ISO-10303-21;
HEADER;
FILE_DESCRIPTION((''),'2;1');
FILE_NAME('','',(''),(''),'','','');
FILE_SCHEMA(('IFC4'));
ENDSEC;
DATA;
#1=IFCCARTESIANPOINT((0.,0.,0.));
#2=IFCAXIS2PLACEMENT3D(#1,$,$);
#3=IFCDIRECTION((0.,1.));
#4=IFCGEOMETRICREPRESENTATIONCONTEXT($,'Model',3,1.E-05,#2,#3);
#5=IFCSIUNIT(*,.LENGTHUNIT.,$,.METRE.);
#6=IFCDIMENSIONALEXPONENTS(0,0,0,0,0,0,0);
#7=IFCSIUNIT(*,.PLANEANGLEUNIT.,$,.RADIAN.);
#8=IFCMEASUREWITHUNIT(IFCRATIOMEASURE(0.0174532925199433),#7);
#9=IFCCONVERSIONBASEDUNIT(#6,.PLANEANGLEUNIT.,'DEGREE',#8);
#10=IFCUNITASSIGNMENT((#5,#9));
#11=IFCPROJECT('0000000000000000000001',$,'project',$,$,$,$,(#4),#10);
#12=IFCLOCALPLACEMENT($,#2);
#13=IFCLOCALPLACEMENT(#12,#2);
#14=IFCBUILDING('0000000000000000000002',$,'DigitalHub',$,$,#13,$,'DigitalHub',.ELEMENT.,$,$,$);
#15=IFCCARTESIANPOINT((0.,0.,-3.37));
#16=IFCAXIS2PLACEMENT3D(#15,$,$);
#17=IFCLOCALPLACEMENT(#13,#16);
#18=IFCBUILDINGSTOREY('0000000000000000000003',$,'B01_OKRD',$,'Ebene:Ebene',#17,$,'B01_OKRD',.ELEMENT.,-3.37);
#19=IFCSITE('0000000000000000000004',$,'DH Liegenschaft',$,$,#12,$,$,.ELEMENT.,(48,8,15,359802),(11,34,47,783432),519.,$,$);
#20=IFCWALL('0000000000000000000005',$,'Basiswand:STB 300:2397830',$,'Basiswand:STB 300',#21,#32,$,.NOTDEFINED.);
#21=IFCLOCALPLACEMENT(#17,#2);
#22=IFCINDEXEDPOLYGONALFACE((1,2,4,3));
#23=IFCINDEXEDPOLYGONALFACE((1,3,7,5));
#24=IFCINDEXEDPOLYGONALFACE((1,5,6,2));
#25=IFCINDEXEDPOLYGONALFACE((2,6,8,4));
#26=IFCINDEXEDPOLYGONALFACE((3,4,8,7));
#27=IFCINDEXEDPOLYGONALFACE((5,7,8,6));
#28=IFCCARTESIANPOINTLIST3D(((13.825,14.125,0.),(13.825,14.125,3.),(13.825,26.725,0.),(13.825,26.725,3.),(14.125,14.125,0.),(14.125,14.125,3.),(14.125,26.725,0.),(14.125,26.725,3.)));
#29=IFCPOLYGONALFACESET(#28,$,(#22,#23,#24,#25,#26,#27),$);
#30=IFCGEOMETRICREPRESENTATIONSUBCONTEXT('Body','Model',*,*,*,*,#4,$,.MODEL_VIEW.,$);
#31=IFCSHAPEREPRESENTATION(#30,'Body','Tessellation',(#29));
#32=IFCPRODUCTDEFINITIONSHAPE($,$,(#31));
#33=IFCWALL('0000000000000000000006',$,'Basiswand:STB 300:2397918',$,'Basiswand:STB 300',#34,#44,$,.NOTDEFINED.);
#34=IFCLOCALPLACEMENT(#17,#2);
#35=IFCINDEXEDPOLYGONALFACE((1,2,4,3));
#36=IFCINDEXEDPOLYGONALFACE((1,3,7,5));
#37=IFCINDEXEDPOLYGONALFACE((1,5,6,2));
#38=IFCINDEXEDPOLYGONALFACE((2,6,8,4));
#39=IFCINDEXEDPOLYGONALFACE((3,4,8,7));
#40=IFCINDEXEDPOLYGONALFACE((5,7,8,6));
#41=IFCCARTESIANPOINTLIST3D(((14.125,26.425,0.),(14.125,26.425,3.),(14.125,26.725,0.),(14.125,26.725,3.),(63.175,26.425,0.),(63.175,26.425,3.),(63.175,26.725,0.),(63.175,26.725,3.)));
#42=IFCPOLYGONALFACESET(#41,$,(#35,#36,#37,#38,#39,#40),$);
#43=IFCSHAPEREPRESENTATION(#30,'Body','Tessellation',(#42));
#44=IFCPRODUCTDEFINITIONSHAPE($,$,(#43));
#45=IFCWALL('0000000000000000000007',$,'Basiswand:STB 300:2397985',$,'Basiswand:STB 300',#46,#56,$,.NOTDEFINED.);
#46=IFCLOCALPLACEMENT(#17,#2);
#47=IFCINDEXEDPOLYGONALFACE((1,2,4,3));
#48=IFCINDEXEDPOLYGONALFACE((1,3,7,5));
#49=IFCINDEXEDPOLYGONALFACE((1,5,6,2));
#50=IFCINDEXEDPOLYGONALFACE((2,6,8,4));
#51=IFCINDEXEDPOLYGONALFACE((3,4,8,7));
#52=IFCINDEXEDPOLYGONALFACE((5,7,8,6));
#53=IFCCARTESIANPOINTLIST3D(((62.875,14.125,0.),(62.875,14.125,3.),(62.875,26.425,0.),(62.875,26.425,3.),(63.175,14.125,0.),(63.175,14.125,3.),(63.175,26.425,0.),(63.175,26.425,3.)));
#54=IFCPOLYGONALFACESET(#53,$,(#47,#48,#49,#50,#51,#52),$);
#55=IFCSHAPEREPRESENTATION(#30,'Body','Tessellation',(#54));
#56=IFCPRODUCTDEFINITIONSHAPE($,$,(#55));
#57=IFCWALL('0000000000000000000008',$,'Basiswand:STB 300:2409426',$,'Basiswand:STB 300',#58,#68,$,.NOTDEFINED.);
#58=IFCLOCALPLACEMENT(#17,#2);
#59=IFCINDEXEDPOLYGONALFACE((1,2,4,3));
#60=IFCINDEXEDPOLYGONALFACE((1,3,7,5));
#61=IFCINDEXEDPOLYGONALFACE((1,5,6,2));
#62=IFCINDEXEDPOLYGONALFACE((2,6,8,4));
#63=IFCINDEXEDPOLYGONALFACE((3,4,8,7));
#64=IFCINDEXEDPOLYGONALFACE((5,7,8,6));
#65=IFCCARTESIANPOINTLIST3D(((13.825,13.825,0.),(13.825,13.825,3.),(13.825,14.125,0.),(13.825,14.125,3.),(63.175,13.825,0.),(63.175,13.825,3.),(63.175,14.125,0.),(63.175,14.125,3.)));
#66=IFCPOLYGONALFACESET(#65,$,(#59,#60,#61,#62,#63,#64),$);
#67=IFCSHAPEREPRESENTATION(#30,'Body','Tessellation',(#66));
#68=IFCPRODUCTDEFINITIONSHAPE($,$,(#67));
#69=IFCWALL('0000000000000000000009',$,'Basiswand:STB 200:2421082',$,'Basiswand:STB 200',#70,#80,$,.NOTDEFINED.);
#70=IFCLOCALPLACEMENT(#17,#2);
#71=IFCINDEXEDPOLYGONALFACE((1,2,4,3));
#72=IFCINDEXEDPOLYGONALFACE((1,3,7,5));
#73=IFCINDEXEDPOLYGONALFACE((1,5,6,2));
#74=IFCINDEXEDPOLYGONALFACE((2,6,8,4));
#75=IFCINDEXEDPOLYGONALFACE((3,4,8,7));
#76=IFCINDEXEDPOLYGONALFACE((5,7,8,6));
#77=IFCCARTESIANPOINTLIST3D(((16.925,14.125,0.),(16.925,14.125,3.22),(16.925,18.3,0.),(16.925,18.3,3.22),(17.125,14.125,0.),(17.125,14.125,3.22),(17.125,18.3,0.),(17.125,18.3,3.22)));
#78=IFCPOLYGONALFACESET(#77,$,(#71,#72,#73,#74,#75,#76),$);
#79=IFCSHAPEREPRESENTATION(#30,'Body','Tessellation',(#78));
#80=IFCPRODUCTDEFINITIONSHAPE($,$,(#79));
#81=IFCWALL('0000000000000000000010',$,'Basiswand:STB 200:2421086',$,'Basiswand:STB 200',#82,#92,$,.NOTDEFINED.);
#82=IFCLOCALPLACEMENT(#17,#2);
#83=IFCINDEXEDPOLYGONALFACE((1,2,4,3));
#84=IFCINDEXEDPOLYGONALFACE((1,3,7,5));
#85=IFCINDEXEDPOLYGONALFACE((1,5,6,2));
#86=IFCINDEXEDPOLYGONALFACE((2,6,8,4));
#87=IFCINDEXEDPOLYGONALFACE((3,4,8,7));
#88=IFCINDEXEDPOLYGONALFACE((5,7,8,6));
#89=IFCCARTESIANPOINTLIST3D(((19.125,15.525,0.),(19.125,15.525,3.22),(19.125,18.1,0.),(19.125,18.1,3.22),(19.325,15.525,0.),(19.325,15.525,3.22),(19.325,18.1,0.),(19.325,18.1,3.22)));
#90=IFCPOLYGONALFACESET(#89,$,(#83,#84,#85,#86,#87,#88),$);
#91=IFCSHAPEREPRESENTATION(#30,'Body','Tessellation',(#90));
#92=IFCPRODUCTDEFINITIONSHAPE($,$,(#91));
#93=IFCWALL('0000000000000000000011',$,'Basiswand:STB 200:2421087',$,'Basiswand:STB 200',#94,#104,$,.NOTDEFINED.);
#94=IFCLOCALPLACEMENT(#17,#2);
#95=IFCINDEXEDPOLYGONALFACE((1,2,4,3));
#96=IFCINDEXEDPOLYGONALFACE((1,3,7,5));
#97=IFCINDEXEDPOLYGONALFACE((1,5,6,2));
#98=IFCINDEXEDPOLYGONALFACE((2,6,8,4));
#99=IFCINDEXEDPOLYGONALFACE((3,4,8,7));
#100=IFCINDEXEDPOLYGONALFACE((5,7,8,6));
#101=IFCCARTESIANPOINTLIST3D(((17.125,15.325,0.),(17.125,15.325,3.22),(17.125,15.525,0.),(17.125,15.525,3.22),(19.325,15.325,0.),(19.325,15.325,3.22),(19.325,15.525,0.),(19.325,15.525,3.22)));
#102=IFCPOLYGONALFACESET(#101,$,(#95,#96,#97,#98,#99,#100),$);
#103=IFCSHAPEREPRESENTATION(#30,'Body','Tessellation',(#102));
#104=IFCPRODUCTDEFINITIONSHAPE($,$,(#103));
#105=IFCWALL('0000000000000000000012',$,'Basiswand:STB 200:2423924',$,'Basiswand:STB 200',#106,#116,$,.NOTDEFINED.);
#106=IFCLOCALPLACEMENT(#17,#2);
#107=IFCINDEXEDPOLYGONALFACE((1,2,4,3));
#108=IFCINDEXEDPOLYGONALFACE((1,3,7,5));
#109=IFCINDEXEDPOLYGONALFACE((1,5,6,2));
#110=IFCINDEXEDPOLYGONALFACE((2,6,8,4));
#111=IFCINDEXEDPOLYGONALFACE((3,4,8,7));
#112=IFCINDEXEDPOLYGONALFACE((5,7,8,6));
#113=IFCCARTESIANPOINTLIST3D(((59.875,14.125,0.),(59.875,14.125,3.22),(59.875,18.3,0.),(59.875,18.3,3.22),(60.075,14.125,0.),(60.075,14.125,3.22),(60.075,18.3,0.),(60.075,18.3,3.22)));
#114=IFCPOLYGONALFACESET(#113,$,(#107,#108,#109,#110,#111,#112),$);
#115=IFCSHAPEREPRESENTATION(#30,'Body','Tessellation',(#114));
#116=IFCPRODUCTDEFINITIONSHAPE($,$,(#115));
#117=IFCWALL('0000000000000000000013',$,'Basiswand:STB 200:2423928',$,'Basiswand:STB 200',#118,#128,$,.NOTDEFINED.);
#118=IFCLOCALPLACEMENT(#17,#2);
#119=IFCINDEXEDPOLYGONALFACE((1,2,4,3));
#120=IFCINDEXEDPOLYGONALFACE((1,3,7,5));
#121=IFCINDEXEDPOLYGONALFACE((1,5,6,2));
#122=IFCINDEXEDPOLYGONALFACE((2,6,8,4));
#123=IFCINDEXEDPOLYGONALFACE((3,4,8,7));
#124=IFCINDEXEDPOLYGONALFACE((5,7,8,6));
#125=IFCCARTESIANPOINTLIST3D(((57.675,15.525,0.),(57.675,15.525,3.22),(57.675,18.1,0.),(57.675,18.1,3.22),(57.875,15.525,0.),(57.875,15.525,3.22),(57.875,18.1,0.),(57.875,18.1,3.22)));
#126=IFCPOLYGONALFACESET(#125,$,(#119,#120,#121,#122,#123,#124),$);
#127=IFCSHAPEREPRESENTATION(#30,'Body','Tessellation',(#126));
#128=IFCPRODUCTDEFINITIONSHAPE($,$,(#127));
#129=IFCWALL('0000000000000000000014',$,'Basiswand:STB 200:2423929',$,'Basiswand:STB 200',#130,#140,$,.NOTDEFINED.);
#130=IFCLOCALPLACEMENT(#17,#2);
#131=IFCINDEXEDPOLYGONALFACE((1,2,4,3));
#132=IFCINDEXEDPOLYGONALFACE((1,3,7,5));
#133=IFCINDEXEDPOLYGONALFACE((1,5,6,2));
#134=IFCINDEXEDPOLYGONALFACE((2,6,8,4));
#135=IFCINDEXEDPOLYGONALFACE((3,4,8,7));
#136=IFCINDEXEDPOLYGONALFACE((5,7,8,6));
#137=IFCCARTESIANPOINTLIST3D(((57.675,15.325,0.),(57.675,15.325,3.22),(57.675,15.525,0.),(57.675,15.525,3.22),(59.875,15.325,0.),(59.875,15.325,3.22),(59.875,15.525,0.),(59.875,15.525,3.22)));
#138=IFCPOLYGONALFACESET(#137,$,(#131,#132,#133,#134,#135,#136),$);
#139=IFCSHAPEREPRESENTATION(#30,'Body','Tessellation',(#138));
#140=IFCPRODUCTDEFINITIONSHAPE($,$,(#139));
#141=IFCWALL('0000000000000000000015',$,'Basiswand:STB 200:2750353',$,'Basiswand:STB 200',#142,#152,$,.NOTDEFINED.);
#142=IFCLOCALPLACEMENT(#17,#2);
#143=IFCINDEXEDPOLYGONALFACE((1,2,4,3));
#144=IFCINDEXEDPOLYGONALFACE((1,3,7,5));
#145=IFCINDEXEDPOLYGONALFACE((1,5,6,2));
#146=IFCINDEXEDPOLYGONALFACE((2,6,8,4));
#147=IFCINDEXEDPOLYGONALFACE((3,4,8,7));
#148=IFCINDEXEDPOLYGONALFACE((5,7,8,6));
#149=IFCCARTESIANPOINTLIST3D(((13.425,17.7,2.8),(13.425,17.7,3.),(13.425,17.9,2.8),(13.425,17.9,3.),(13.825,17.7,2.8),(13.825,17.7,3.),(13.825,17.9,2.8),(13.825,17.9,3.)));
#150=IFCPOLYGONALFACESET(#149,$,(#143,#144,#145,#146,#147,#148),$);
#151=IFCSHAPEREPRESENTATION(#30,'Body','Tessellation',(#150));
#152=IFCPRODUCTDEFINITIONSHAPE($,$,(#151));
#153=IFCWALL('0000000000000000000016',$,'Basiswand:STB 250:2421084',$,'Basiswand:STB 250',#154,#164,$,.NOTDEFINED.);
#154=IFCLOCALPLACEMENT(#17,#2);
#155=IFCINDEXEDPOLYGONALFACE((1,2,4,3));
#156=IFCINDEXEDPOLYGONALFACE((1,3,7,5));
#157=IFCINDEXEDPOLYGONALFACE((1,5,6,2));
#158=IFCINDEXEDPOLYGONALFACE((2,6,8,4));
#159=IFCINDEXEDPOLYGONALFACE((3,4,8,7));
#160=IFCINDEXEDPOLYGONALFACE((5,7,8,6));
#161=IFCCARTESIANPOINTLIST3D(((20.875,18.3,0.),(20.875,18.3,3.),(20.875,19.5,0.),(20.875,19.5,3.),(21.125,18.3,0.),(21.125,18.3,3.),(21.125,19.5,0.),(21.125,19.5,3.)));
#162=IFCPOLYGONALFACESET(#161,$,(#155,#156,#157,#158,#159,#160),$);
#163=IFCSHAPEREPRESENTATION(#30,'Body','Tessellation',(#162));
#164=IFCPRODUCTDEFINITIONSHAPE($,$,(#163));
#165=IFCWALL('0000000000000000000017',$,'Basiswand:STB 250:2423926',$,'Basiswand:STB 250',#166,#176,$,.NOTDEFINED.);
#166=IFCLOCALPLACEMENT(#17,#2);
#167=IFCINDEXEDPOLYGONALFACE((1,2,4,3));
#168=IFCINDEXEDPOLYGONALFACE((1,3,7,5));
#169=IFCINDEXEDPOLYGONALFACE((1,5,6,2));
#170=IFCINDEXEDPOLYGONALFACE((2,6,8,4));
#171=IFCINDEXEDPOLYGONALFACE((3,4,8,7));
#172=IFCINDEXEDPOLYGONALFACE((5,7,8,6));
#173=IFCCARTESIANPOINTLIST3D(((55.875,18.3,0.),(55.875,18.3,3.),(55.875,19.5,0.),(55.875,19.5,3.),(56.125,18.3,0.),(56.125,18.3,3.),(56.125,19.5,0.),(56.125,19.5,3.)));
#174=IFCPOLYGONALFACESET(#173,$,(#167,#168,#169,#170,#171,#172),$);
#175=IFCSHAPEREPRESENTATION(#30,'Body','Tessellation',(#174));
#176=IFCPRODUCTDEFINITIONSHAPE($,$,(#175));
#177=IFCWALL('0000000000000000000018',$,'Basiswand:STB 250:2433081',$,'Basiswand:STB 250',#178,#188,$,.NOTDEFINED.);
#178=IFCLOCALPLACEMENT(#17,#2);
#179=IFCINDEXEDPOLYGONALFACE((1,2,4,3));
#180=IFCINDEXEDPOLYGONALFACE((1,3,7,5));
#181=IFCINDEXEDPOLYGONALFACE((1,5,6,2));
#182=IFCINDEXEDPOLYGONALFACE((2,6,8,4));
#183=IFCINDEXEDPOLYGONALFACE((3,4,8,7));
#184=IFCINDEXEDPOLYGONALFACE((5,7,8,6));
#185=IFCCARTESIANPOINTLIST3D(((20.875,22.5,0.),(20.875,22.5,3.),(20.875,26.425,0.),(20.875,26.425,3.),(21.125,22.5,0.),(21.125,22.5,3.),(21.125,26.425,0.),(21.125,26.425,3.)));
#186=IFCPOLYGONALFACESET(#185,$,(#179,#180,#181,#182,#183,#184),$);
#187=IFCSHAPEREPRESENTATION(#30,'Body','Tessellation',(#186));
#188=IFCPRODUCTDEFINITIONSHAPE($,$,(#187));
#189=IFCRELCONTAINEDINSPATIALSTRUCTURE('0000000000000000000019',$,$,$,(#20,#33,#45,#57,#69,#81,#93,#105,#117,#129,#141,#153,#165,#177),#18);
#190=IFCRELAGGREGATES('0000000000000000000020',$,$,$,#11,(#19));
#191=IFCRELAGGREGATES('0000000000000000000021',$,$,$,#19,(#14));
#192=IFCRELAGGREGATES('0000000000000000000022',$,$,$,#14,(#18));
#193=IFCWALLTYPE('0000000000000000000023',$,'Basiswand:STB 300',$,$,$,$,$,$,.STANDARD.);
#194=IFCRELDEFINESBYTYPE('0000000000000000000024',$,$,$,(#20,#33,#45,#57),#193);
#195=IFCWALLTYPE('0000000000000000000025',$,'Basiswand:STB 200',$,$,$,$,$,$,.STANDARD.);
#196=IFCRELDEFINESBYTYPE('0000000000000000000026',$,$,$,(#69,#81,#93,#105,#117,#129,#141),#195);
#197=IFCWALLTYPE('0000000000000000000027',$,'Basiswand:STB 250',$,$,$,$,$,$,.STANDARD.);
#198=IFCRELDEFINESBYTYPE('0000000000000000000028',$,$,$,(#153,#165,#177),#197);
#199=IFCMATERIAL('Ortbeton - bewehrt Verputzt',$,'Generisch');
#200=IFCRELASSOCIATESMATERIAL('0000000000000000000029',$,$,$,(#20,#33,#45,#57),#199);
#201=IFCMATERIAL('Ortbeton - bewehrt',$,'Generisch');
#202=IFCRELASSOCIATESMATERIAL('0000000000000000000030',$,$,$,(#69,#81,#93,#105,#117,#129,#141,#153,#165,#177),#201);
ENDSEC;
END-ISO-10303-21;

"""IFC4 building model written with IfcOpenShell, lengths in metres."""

from ifc_helpers import new_model, entity, si_unit, converted_unit, direction, frame, origin, place, context, subcontext, project, spatial, indexed_curve, outline, extrude, material, type_object, element, save


model = new_model("IFC4")

# Units and contexts
model_context = context("Model", 3, precision=1e-05, world=origin(), true_north=direction((0.0, 1.0)))
body_context = subcontext(model_context, "Body", "Model", "MODEL_VIEW")
ifc_project = project(units=[si_unit("LENGTHUNIT", "METRE"), converted_unit("PLANEANGLEUNIT", "DEGREE", entity("IfcRatioMeasure", 0.0174532925199433), si_unit("PLANEANGLEUNIT", "RADIAN"), dimensions=[0, 0, 0, 0, 0, 0, 0])], contexts=[model_context])

# Site, building, storey
site_placement = place(None, frame((0.0, 0.0, 0.0)))
site = spatial("IfcSite", under=ifc_project, at=site_placement, Name="DH Liegenschaft", CompositionType="ELEMENT", RefLatitude=(48, 8, 15, 359802), RefLongitude=(11, 34, 47, 783432), RefElevation=519.0)
building_placement = place(site_placement, origin())
building = spatial("IfcBuilding", under=site, at=building_placement, Name="DigitalHub", LongName="DigitalHub", CompositionType="ELEMENT")
storey_placement = place(building_placement, frame((0.0, 0.0, -3.37)))
storey = spatial("IfcBuildingStorey", under=building, at=storey_placement, Name="B01_OKRD", ObjectType="Ebene:Ebene", LongName="B01_OKRD", CompositionType="ELEMENT", Elevation=-3.37)

# Walls
ifc_material_1 = material(Name="Ortbeton - bewehrt Verputzt", Category="Generisch")
wall_type_1 = type_object("IfcWallType", Name="Basiswand:STB 300", PredefinedType="STANDARD")
wall_1_placement = place(storey_placement, frame((13.975, 14.125, 0.0), z_axis=(0.0, 0.0, 1.0), x_axis=(0.0, 1.0, 0.0)))
element("IfcWall", 1, at=wall_1_placement, inside=storey, type_object=wall_type_1, material=ifc_material_1, Name="Basiswand:STB 300:2397830", ObjectType="Basiswand:STB 300", PredefinedType="NOTDEFINED", context=body_context, shape_type="SweptSolid", body=[
    extrude(outline(indexed_curve([(12.6, 0.15), (0.0, 0.15), (0.0, -0.15), (12.6, -0.15), (12.6, 0.15)], self_intersect=False)), origin(), (0.0, 0.0, 1.0), 3.0),
])
wall_2_placement = place(storey_placement, frame((14.125, 26.575, 0.0)))
element("IfcWall", 2, at=wall_2_placement, inside=storey, type_object=wall_type_1, material=ifc_material_1, Name="Basiswand:STB 300:2397918", ObjectType="Basiswand:STB 300", PredefinedType="NOTDEFINED", context=body_context, shape_type="SweptSolid", body=[
    extrude(outline(indexed_curve([(49.05, 0.15), (0.0, 0.15), (0.0, -0.15), (49.05, -0.15), (49.05, 0.15)], self_intersect=False)), origin(), (0.0, 0.0, 1.0), 3.0),
])
wall_3_placement = place(storey_placement, frame((63.025, 26.425, 0.0), z_axis=(0.0, 0.0, 1.0), x_axis=(0.0, -1.0, 0.0)))
element("IfcWall", 3, at=wall_3_placement, inside=storey, type_object=wall_type_1, material=ifc_material_1, Name="Basiswand:STB 300:2397985", ObjectType="Basiswand:STB 300", PredefinedType="NOTDEFINED", context=body_context, shape_type="SweptSolid", body=[
    extrude(outline(indexed_curve([(12.3, 0.15), (0.0, 0.15), (0.0, -0.15), (12.3, -0.15), (12.3, 0.15)], self_intersect=False)), origin(), (0.0, 0.0, 1.0), 3.0),
])
wall_4_placement = place(storey_placement, frame((63.175, 13.975, 0.0), z_axis=(0.0, 0.0, 1.0), x_axis=(-1.0, 0.0, 0.0)))
element("IfcWall", 4, at=wall_4_placement, inside=storey, type_object=wall_type_1, material=ifc_material_1, Name="Basiswand:STB 300:2409426", ObjectType="Basiswand:STB 300", PredefinedType="NOTDEFINED", context=body_context, shape_type="SweptSolid", body=[
    extrude(outline(indexed_curve([(49.35, 0.15), (0.0, 0.15), (0.0, -0.15), (49.35, -0.15), (49.35, 0.15)], self_intersect=False)), origin(), (0.0, 0.0, 1.0), 3.0),
])
ifc_material_2 = material(Name="Ortbeton - bewehrt", Category="Generisch")
wall_type_2 = type_object("IfcWallType", Name="Basiswand:STB 200", PredefinedType="STANDARD")
wall_5_placement = place(storey_placement, frame((17.025, 14.125, 0.0), z_axis=(0.0, 0.0, 1.0), x_axis=(0.0, 1.0, 0.0)))
element("IfcWall", 5, at=wall_5_placement, inside=storey, type_object=wall_type_2, material=ifc_material_2, Name="Basiswand:STB 200:2421082", ObjectType="Basiswand:STB 200", PredefinedType="NOTDEFINED", context=body_context, shape_type="SweptSolid", body=[
    extrude(outline(indexed_curve([(4.175, 0.1), (0.0, 0.1), (0.0, -0.1), (4.175, -0.1), (4.175, 0.1)], self_intersect=False)), origin(), (0.0, 0.0, 1.0), 3.22),
])
wall_6_placement = place(storey_placement, frame((19.225, 15.525, 0.0), z_axis=(0.0, 0.0, 1.0), x_axis=(0.0, 1.0, 0.0)))
element("IfcWall", 6, at=wall_6_placement, inside=storey, type_object=wall_type_2, material=ifc_material_2, Name="Basiswand:STB 200:2421086", ObjectType="Basiswand:STB 200", PredefinedType="NOTDEFINED", context=body_context, shape_type="SweptSolid", body=[
    extrude(outline(indexed_curve([(2.575, 0.1), (0.0, 0.1), (0.0, -0.1), (2.575, -0.1), (2.575, 0.1)], self_intersect=False)), origin(), (0.0, 0.0, 1.0), 3.22),
])
wall_7_placement = place(storey_placement, frame((17.125, 15.425, 0.0)))
element("IfcWall", 7, at=wall_7_placement, inside=storey, type_object=wall_type_2, material=ifc_material_2, Name="Basiswand:STB 200:2421087", ObjectType="Basiswand:STB 200", PredefinedType="NOTDEFINED", context=body_context, shape_type="SweptSolid", body=[
    extrude(outline(indexed_curve([(2.2, 0.1), (0.0, 0.1), (0.0, -0.1), (2.2, -0.1), (2.2, 0.1)], self_intersect=False)), origin(), (0.0, 0.0, 1.0), 3.22),
])
wall_8_placement = place(storey_placement, frame((59.975, 14.125, 0.0), z_axis=(0.0, 0.0, 1.0), x_axis=(0.0, 1.0, 0.0)))
element("IfcWall", 8, at=wall_8_placement, inside=storey, type_object=wall_type_2, material=ifc_material_2, Name="Basiswand:STB 200:2423924", ObjectType="Basiswand:STB 200", PredefinedType="NOTDEFINED", context=body_context, shape_type="SweptSolid", body=[
    extrude(outline(indexed_curve([(4.175, 0.1), (0.0, 0.1), (0.0, -0.1), (4.175, -0.1), (4.175, 0.1)], self_intersect=False)), origin(), (0.0, 0.0, 1.0), 3.22),
])
wall_9_placement = place(storey_placement, frame((57.775, 15.525, 0.0), z_axis=(0.0, 0.0, 1.0), x_axis=(0.0, 1.0, 0.0)))
element("IfcWall", 9, at=wall_9_placement, inside=storey, type_object=wall_type_2, material=ifc_material_2, Name="Basiswand:STB 200:2423928", ObjectType="Basiswand:STB 200", PredefinedType="NOTDEFINED", context=body_context, shape_type="SweptSolid", body=[
    extrude(outline(indexed_curve([(2.575, 0.1), (0.0, 0.1), (0.0, -0.1), (2.575, -0.1), (2.575, 0.1)], self_intersect=False)), origin(), (0.0, 0.0, 1.0), 3.22),
])
wall_10_placement = place(storey_placement, frame((59.875, 15.425, 0.0), z_axis=(0.0, 0.0, 1.0), x_axis=(-1.0, 0.0, 0.0)))
element("IfcWall", 10, at=wall_10_placement, inside=storey, type_object=wall_type_2, material=ifc_material_2, Name="Basiswand:STB 200:2423929", ObjectType="Basiswand:STB 200", PredefinedType="NOTDEFINED", context=body_context, shape_type="SweptSolid", body=[
    extrude(outline(indexed_curve([(2.2, 0.1), (0.0, 0.1), (0.0, -0.1), (2.2, -0.1), (2.2, 0.1)], self_intersect=False)), origin(), (0.0, 0.0, 1.0), 3.22),
])
wall_11_placement = place(storey_placement, frame((13.825, 17.8, 2.8), z_axis=(0.0, 0.0, 1.0), x_axis=(-1.0, 0.0, 0.0)))
element("IfcWall", 11, at=wall_11_placement, inside=storey, type_object=wall_type_2, material=ifc_material_2, Name="Basiswand:STB 200:2750353", ObjectType="Basiswand:STB 200", PredefinedType="NOTDEFINED", context=body_context, shape_type="SweptSolid", body=[
    extrude(outline(indexed_curve([(0.4, 0.1), (0.0, 0.1), (0.0, -0.1), (0.4, -0.1), (0.4, 0.1)], self_intersect=False)), origin(), (0.0, 0.0, 1.0), 0.2),
])
wall_type_3 = type_object("IfcWallType", Name="Basiswand:STB 250", PredefinedType="STANDARD")
wall_12_placement = place(storey_placement, frame((21.0, 19.5, 0.0), z_axis=(0.0, 0.0, 1.0), x_axis=(0.0, -1.0, 0.0)))
element("IfcWall", 12, at=wall_12_placement, inside=storey, type_object=wall_type_3, material=ifc_material_2, Name="Basiswand:STB 250:2421084", ObjectType="Basiswand:STB 250", PredefinedType="NOTDEFINED", context=body_context, shape_type="SweptSolid", body=[
    extrude(outline(indexed_curve([(1.2, 0.125), (0.0, 0.125), (0.0, -0.125), (1.2, -0.125), (1.2, 0.125)], self_intersect=False)), origin(), (0.0, 0.0, 1.0), 3.0),
])
wall_13_placement = place(storey_placement, frame((56.0, 19.5, 0.0), z_axis=(0.0, 0.0, 1.0), x_axis=(0.0, -1.0, 0.0)))
element("IfcWall", 13, at=wall_13_placement, inside=storey, type_object=wall_type_3, material=ifc_material_2, Name="Basiswand:STB 250:2423926", ObjectType="Basiswand:STB 250", PredefinedType="NOTDEFINED", context=body_context, shape_type="SweptSolid", body=[
    extrude(outline(indexed_curve([(1.2, 0.125), (0.0, 0.125), (0.0, -0.125), (1.2, -0.125), (1.2, 0.125)], self_intersect=False)), origin(), (0.0, 0.0, 1.0), 3.0),
])
wall_14_placement = place(storey_placement, frame((21.0, 26.425, 0.0), z_axis=(0.0, 0.0, 1.0), x_axis=(0.0, -1.0, 0.0)))
element("IfcWall", 14, at=wall_14_placement, inside=storey, type_object=wall_type_3, material=ifc_material_2, Name="Basiswand:STB 250:2433081", ObjectType="Basiswand:STB 250", PredefinedType="NOTDEFINED", context=body_context, shape_type="SweptSolid", body=[
    extrude(outline(indexed_curve([(3.925, 0.125), (0.0, 0.125), (0.0, -0.125), (3.925, -0.125), (3.925, 0.125)], self_intersect=False)), origin(), (0.0, 0.0, 1.0), 3.0),
])

save(model, "model.ifc")
